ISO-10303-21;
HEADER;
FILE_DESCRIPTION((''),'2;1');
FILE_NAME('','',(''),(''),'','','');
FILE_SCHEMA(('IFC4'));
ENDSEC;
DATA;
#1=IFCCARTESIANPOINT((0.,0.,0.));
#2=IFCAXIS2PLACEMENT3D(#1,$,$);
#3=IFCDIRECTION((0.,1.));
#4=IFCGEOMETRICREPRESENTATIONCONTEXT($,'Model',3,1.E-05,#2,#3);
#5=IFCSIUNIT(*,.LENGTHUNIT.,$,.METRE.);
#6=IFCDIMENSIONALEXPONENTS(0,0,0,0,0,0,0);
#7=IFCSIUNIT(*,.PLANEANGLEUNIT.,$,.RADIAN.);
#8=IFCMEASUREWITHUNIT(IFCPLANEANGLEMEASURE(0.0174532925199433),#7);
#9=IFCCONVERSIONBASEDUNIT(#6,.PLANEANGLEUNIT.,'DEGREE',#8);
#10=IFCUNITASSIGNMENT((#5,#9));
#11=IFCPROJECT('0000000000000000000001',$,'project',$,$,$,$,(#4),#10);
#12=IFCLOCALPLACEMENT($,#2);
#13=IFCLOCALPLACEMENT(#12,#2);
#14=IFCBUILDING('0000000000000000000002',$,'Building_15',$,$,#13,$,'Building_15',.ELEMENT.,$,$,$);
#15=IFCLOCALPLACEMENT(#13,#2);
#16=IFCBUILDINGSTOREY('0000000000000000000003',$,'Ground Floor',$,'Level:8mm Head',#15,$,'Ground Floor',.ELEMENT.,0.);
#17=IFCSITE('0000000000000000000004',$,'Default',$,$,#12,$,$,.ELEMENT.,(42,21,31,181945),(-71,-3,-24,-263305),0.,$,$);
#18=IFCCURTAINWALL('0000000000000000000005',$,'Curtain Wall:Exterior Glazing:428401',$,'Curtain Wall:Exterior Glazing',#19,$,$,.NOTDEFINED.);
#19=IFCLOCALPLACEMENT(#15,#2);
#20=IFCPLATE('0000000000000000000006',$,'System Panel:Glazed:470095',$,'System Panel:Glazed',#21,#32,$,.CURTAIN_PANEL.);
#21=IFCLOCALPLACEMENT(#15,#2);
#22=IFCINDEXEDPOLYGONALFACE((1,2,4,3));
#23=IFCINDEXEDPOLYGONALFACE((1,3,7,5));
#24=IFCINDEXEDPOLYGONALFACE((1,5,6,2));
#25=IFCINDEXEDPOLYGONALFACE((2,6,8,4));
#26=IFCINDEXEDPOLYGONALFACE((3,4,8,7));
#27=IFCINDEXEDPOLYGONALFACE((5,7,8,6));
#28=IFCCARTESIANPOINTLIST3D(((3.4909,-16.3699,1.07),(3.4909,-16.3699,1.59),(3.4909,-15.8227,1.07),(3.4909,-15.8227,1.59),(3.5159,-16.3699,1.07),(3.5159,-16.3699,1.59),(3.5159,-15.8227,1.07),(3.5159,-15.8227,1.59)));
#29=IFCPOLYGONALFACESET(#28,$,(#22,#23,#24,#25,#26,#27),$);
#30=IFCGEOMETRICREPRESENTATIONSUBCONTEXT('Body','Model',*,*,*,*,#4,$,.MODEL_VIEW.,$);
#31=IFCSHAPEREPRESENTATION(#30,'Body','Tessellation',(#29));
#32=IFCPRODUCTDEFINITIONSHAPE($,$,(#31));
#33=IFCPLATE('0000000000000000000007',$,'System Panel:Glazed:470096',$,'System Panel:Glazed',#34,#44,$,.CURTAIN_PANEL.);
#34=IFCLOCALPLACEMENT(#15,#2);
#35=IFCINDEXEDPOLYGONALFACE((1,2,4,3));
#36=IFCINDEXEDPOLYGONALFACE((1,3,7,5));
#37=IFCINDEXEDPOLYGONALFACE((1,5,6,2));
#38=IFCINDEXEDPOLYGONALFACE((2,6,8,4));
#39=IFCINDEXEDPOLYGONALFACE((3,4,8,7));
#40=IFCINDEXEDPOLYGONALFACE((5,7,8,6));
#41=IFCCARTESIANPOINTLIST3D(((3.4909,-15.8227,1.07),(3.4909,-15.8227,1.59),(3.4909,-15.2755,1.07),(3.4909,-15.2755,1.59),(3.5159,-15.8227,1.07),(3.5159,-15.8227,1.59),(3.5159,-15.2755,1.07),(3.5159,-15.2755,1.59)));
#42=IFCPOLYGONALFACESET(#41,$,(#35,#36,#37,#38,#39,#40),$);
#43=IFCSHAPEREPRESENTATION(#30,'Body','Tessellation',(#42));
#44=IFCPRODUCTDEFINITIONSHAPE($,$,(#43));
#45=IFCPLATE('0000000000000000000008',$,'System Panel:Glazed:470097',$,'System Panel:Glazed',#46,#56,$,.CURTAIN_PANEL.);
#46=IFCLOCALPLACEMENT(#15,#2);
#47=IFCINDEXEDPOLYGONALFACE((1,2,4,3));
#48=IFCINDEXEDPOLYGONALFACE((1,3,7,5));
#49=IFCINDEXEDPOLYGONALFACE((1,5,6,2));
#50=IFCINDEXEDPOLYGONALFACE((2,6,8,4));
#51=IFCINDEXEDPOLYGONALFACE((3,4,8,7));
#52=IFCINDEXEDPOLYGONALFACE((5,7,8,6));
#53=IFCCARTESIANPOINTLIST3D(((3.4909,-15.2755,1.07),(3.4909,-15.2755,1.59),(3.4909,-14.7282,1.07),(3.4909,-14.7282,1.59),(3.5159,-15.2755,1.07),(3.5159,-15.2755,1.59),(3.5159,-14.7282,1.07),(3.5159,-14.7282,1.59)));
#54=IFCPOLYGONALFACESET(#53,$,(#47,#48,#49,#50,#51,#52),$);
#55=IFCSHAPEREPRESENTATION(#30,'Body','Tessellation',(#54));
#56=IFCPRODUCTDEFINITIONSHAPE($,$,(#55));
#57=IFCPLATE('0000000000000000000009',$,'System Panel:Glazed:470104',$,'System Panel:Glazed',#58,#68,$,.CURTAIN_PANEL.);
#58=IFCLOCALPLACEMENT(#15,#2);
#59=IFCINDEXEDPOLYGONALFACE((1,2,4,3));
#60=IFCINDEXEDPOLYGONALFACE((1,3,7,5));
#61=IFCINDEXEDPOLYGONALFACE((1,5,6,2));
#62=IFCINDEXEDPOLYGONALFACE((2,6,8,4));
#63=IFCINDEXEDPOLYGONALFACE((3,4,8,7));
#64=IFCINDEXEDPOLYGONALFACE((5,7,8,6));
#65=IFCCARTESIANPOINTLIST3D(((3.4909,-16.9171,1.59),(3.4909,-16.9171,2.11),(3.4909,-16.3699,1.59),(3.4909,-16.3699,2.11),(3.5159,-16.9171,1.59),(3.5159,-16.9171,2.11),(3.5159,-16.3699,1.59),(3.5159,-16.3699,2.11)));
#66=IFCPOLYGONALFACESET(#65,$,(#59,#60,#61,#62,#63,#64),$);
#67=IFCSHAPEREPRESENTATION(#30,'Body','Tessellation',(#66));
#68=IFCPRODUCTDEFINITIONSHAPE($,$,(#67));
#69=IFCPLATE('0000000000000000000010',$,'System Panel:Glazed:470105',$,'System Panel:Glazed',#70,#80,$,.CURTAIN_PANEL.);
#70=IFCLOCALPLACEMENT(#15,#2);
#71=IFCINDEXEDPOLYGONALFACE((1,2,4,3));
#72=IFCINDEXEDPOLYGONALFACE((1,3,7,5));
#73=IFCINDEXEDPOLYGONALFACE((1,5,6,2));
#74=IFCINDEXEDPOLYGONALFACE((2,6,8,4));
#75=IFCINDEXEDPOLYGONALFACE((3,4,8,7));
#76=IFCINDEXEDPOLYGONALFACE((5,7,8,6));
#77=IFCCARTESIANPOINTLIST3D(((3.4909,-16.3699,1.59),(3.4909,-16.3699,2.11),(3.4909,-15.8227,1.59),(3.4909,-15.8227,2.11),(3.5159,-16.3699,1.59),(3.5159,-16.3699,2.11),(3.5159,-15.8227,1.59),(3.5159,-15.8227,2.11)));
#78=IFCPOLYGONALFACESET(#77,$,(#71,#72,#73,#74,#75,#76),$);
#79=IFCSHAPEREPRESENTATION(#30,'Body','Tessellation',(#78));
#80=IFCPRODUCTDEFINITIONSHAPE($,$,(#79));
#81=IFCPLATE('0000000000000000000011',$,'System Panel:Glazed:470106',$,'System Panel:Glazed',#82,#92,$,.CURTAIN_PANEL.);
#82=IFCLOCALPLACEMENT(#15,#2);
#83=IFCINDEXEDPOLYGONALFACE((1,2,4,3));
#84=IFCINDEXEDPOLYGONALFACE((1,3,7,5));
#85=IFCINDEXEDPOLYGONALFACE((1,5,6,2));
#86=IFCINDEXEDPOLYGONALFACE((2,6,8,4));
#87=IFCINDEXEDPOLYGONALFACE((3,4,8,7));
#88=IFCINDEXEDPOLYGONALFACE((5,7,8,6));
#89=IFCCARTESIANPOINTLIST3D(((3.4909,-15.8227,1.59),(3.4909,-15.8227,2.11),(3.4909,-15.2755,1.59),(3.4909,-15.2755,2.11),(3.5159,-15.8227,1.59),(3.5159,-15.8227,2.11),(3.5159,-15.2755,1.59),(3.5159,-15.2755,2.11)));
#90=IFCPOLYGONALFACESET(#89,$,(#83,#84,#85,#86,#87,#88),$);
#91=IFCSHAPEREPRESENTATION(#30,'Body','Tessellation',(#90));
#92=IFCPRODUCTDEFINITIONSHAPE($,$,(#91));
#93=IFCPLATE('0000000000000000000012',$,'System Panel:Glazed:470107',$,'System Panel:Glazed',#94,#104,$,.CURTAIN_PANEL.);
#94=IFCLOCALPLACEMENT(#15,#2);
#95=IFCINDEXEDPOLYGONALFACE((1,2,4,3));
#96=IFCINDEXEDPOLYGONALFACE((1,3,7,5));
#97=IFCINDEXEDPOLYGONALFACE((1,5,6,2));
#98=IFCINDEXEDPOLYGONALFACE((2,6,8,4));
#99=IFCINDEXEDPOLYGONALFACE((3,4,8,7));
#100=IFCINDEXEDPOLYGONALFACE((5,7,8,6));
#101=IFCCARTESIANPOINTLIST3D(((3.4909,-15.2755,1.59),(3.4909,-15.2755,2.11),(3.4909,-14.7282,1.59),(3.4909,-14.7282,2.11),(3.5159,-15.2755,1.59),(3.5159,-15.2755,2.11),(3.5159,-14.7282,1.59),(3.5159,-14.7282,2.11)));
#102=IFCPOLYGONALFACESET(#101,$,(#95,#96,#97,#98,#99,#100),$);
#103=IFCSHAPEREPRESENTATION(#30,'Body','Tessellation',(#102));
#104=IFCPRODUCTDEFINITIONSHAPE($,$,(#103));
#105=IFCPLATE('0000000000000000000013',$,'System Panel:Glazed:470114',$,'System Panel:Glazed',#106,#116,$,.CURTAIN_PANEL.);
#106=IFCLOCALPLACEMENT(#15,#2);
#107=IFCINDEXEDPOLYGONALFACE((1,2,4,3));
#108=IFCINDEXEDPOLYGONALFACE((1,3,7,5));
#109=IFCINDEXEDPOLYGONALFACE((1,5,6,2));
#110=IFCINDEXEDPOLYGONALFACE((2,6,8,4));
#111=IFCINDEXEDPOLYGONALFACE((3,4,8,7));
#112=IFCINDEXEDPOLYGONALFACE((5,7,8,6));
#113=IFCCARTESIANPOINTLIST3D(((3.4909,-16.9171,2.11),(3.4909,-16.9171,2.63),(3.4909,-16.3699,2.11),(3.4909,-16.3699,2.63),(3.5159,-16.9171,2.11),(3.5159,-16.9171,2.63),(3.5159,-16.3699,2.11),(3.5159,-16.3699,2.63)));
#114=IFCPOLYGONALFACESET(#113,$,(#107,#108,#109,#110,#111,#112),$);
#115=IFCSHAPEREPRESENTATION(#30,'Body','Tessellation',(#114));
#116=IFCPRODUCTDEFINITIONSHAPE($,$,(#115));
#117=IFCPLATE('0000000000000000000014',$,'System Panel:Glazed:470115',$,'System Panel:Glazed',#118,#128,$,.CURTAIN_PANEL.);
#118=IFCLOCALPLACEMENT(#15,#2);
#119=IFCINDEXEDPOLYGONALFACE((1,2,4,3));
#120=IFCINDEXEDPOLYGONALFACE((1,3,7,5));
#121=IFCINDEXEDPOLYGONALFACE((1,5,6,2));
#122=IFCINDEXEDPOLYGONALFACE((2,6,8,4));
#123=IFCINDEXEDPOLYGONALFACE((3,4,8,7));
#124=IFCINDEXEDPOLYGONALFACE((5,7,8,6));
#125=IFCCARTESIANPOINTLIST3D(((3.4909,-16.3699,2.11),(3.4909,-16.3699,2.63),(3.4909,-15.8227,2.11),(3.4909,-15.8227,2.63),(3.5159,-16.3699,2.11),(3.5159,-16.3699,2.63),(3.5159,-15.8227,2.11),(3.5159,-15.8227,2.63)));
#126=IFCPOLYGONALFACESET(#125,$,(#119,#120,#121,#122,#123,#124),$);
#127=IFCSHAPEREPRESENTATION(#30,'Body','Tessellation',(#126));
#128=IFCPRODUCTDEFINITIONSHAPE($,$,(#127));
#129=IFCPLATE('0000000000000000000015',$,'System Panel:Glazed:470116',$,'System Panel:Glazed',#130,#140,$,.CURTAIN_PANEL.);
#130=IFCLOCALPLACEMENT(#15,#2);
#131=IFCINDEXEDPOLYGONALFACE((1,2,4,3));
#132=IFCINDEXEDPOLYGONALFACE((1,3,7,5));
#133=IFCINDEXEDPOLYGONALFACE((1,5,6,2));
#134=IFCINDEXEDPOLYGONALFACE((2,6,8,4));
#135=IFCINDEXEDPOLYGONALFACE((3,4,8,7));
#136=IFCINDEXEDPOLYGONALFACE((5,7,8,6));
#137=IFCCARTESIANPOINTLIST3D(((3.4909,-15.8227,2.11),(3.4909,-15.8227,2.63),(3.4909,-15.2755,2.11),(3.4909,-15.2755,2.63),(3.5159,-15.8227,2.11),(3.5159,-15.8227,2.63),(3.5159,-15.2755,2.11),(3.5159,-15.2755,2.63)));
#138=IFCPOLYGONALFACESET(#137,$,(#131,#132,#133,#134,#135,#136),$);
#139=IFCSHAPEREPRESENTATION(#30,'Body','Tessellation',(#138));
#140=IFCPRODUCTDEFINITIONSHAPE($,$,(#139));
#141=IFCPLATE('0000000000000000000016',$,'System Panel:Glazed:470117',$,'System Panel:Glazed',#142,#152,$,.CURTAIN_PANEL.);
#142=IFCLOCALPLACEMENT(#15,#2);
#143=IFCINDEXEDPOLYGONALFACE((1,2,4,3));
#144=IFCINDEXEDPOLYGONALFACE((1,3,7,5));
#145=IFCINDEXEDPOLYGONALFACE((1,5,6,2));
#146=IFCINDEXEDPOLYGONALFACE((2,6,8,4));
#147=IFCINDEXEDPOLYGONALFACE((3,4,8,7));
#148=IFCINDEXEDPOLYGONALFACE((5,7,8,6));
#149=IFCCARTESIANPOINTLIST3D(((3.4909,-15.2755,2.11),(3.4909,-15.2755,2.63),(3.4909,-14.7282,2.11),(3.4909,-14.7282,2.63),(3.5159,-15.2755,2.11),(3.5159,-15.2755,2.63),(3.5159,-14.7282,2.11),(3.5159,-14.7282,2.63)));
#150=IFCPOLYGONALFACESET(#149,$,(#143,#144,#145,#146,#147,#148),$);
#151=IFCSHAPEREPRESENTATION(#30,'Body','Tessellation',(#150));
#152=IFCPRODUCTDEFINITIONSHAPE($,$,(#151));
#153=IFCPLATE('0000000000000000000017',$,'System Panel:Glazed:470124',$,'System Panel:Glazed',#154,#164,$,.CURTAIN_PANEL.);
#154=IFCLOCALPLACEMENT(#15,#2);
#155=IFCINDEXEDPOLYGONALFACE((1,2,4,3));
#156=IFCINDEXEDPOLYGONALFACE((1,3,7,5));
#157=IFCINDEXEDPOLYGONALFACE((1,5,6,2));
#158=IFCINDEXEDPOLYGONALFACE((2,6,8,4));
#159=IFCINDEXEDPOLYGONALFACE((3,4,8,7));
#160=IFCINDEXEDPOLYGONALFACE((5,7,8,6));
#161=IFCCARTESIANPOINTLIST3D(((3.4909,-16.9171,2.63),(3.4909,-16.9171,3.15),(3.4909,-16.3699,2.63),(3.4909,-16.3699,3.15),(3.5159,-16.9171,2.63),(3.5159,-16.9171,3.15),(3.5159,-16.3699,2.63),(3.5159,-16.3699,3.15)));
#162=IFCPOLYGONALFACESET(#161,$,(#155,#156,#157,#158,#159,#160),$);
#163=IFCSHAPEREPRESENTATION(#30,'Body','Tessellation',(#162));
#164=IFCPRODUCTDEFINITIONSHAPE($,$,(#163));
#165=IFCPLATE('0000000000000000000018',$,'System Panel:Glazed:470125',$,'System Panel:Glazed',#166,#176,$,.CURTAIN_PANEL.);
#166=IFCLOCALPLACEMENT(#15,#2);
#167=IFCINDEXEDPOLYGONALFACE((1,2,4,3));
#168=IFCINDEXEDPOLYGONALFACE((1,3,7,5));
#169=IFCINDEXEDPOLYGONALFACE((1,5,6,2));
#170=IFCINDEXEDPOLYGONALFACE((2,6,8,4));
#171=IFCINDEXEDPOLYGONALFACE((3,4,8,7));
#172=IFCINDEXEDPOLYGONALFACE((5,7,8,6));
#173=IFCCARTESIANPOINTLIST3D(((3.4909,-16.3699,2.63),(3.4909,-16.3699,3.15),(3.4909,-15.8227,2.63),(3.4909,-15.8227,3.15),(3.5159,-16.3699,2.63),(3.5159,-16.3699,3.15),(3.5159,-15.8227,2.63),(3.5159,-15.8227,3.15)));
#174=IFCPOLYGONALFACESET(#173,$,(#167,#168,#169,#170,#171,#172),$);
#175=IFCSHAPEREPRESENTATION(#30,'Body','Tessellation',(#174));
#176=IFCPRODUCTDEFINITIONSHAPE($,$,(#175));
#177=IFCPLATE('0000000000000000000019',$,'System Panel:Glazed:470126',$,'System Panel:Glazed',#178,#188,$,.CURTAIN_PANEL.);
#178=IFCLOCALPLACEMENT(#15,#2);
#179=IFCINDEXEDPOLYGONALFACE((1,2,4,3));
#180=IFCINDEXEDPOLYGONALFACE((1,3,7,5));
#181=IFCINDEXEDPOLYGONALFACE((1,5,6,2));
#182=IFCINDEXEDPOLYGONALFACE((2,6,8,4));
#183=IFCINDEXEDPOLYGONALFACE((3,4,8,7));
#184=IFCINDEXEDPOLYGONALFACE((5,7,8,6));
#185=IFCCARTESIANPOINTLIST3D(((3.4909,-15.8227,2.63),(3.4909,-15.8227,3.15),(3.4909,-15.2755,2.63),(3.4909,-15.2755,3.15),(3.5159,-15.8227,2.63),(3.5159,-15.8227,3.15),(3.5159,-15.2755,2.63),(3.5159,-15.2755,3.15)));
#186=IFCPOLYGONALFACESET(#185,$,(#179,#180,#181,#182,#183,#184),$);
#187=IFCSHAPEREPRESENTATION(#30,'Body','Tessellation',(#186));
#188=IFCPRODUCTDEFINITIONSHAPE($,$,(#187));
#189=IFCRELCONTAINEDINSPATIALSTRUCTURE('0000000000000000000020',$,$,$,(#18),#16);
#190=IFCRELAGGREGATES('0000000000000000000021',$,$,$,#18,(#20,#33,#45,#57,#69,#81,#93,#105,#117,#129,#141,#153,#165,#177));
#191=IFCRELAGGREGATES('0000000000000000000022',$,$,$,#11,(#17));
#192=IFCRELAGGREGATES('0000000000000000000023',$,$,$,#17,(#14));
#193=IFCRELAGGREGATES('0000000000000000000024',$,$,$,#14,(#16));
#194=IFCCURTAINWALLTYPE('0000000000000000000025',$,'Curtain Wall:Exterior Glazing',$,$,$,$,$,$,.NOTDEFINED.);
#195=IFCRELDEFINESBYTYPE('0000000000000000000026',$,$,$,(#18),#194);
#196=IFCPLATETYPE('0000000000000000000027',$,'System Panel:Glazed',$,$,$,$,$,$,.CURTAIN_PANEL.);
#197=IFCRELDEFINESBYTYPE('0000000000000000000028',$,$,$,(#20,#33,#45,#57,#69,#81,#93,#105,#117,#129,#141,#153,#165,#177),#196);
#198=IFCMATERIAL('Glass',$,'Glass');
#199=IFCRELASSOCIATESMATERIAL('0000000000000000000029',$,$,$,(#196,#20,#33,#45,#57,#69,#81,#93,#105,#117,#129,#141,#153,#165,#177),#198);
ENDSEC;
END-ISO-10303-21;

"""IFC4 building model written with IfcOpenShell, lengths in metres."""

from ifc_helpers import new_model, entity, si_unit, converted_unit, direction, frame, origin, place, context, subcontext, project, spatial, indexed_curve, outline, extrude, source, transform, mapped, material, type_object, type_shapes, element, aggregate, save


model = new_model("IFC4")

# Units and contexts
model_context = context("Model", 3, precision=1e-05, world=origin(), true_north=direction((0.0, 1.0)))
body_context = subcontext(model_context, "Body", "Model", "MODEL_VIEW")
ifc_project = project(units=[si_unit("LENGTHUNIT", "METRE"), converted_unit("PLANEANGLEUNIT", "DEGREE", entity("IfcPlaneAngleMeasure", 0.0174532925199433), si_unit("PLANEANGLEUNIT", "RADIAN"), dimensions=[0, 0, 0, 0, 0, 0, 0])], contexts=[model_context])

# Site, building, storey
site_placement = place(None, origin())
site = spatial("IfcSite", under=ifc_project, at=site_placement, Name="Default", CompositionType="ELEMENT", RefLatitude=(42, 21, 31, 181945), RefLongitude=(-71, -3, -24, -263305), RefElevation=0.0)
building_placement = place(site_placement, origin())
building = spatial("IfcBuilding", under=site, at=building_placement, Name="Building_15", LongName="Building_15", CompositionType="ELEMENT")
storey_placement = place(building_placement, origin())
storey = spatial("IfcBuildingStorey", under=building, at=storey_placement, Name="Ground Floor", ObjectType="Level:8mm Head", LongName="Ground Floor", CompositionType="ELEMENT", Elevation=0.0)

# Curtain wall, plates
curtain_wall_type = type_object("IfcCurtainWallType", Name="Curtain Wall:Exterior Glazing", PredefinedType="NOTDEFINED")
curtain_wall_placement = place(storey_placement, origin())
curtain_wall = element("IfcCurtainWall", 1, at=curtain_wall_placement, inside=storey, type_object=curtain_wall_type, Name="Curtain Wall:Exterior Glazing:428401", ObjectType="Curtain Wall:Exterior Glazing", PredefinedType="NOTDEFINED")
ifc_material_1 = material(Name="Glass", Category="Glass")
plate_type_1 = type_object("IfcPlateType", Name="System Panel:Glazed", PredefinedType="CURTAIN_PANEL", material=ifc_material_1)
shared_shape_1 = source(origin(), body_context, "Body", "SweptSolid", [
    extrude(outline(indexed_curve([(-0.0125, -0.2736), (0.0125, -0.2736), (0.0125, 0.2736), (-0.0125, 0.2736), (-0.0125, -0.2736)], self_intersect=False)), frame((0.0, 0.037, 0.0), z_axis=(0.0, 0.0, 1.0), x_axis=(0.0, 1.0, 0.0)), (0.0, 0.0, 1.0), 0.52),
])
type_shapes(plate_type_1, [shared_shape_1])
plate_1_placement = place(curtain_wall_placement, frame((3.5404, -16.0963, 1.07), z_axis=(0.0, 0.0, 1.0), x_axis=(0.0, 1.0, 0.0)))
plate_1 = element("IfcPlate", 2, at=plate_1_placement, type_object=plate_type_1, material=ifc_material_1, Name="System Panel:Glazed:470095", ObjectType="System Panel:Glazed", PredefinedType="CURTAIN_PANEL", context=body_context, shape_type="MappedRepresentation", body=[
    mapped(shared_shape_1, transform((0.0, 0.0, 0.0), scale=1.0)),
])
plate_2_placement = place(curtain_wall_placement, frame((3.5404, -15.5491, 1.07), z_axis=(0.0, 0.0, 1.0), x_axis=(0.0, 1.0, 0.0)))
plate_2 = element("IfcPlate", 3, at=plate_2_placement, type_object=plate_type_1, material=ifc_material_1, Name="System Panel:Glazed:470096", ObjectType="System Panel:Glazed", PredefinedType="CURTAIN_PANEL", context=body_context, shape_type="MappedRepresentation", body=[
    mapped(shared_shape_1, transform((0.0, 0.0, 0.0), scale=1.0)),
])
plate_3_placement = place(curtain_wall_placement, frame((3.5404, -15.0018, 1.07), z_axis=(0.0, 0.0, 1.0), x_axis=(0.0, 1.0, 0.0)))
plate_3 = element("IfcPlate", 4, at=plate_3_placement, type_object=plate_type_1, material=ifc_material_1, Name="System Panel:Glazed:470097", ObjectType="System Panel:Glazed", PredefinedType="CURTAIN_PANEL", context=body_context, shape_type="MappedRepresentation", body=[
    mapped(shared_shape_1, transform((0.0, 0.0, 0.0), scale=1.0)),
])
plate_4_placement = place(curtain_wall_placement, frame((3.5404, -16.6435, 1.59), z_axis=(0.0, 0.0, 1.0), x_axis=(0.0, 1.0, 0.0)))
plate_4 = element("IfcPlate", 5, at=plate_4_placement, type_object=plate_type_1, material=ifc_material_1, Name="System Panel:Glazed:470104", ObjectType="System Panel:Glazed", PredefinedType="CURTAIN_PANEL", context=body_context, shape_type="MappedRepresentation", body=[
    mapped(shared_shape_1, transform((0.0, 0.0, 0.0), scale=1.0)),
])
plate_5_placement = place(curtain_wall_placement, frame((3.5404, -16.0963, 1.59), z_axis=(0.0, 0.0, 1.0), x_axis=(0.0, 1.0, 0.0)))
plate_5 = element("IfcPlate", 6, at=plate_5_placement, type_object=plate_type_1, material=ifc_material_1, Name="System Panel:Glazed:470105", ObjectType="System Panel:Glazed", PredefinedType="CURTAIN_PANEL", context=body_context, shape_type="MappedRepresentation", body=[
    mapped(shared_shape_1, transform((0.0, 0.0, 0.0), scale=1.0)),
])
plate_6_placement = place(curtain_wall_placement, frame((3.5404, -15.5491, 1.59), z_axis=(0.0, 0.0, 1.0), x_axis=(0.0, 1.0, 0.0)))
plate_6 = element("IfcPlate", 7, at=plate_6_placement, type_object=plate_type_1, material=ifc_material_1, Name="System Panel:Glazed:470106", ObjectType="System Panel:Glazed", PredefinedType="CURTAIN_PANEL", context=body_context, shape_type="MappedRepresentation", body=[
    mapped(shared_shape_1, transform((0.0, 0.0, 0.0), scale=1.0)),
])
plate_7_placement = place(curtain_wall_placement, frame((3.5404, -15.0018, 1.59), z_axis=(0.0, 0.0, 1.0), x_axis=(0.0, 1.0, 0.0)))
plate_7 = element("IfcPlate", 8, at=plate_7_placement, type_object=plate_type_1, material=ifc_material_1, Name="System Panel:Glazed:470107", ObjectType="System Panel:Glazed", PredefinedType="CURTAIN_PANEL", context=body_context, shape_type="MappedRepresentation", body=[
    mapped(shared_shape_1, transform((0.0, 0.0, 0.0), scale=1.0)),
])
plate_8_placement = place(curtain_wall_placement, frame((3.5404, -16.6435, 2.11), z_axis=(0.0, 0.0, 1.0), x_axis=(0.0, 1.0, 0.0)))
plate_8 = element("IfcPlate", 9, at=plate_8_placement, type_object=plate_type_1, material=ifc_material_1, Name="System Panel:Glazed:470114", ObjectType="System Panel:Glazed", PredefinedType="CURTAIN_PANEL", context=body_context, shape_type="MappedRepresentation", body=[
    mapped(shared_shape_1, transform((0.0, 0.0, 0.0), scale=1.0)),
])
plate_9_placement = place(curtain_wall_placement, frame((3.5404, -16.0963, 2.11), z_axis=(0.0, 0.0, 1.0), x_axis=(0.0, 1.0, 0.0)))
plate_9 = element("IfcPlate", 10, at=plate_9_placement, type_object=plate_type_1, material=ifc_material_1, Name="System Panel:Glazed:470115", ObjectType="System Panel:Glazed", PredefinedType="CURTAIN_PANEL", context=body_context, shape_type="MappedRepresentation", body=[
    mapped(shared_shape_1, transform((0.0, 0.0, 0.0), scale=1.0)),
])
plate_10_placement = place(curtain_wall_placement, frame((3.5404, -15.5491, 2.11), z_axis=(0.0, 0.0, 1.0), x_axis=(0.0, 1.0, 0.0)))
plate_10 = element("IfcPlate", 11, at=plate_10_placement, type_object=plate_type_1, material=ifc_material_1, Name="System Panel:Glazed:470116", ObjectType="System Panel:Glazed", PredefinedType="CURTAIN_PANEL", context=body_context, shape_type="MappedRepresentation", body=[
    mapped(shared_shape_1, transform((0.0, 0.0, 0.0), scale=1.0)),
])
plate_11_placement = place(curtain_wall_placement, frame((3.5404, -15.0018, 2.11), z_axis=(0.0, 0.0, 1.0), x_axis=(0.0, 1.0, 0.0)))
plate_11 = element("IfcPlate", 12, at=plate_11_placement, type_object=plate_type_1, material=ifc_material_1, Name="System Panel:Glazed:470117", ObjectType="System Panel:Glazed", PredefinedType="CURTAIN_PANEL", context=body_context, shape_type="MappedRepresentation", body=[
    mapped(shared_shape_1, transform((0.0, 0.0, 0.0), scale=1.0)),
])
plate_12_placement = place(curtain_wall_placement, frame((3.5404, -16.6435, 2.63), z_axis=(0.0, 0.0, 1.0), x_axis=(0.0, 1.0, 0.0)))
plate_12 = element("IfcPlate", 13, at=plate_12_placement, type_object=plate_type_1, material=ifc_material_1, Name="System Panel:Glazed:470124", ObjectType="System Panel:Glazed", PredefinedType="CURTAIN_PANEL", context=body_context, shape_type="MappedRepresentation", body=[
    mapped(shared_shape_1, transform((0.0, 0.0, 0.0), scale=1.0)),
])
plate_13_placement = place(curtain_wall_placement, frame((3.5404, -16.0963, 2.63), z_axis=(0.0, 0.0, 1.0), x_axis=(0.0, 1.0, 0.0)))
plate_13 = element("IfcPlate", 14, at=plate_13_placement, type_object=plate_type_1, material=ifc_material_1, Name="System Panel:Glazed:470125", ObjectType="System Panel:Glazed", PredefinedType="CURTAIN_PANEL", context=body_context, shape_type="MappedRepresentation", body=[
    mapped(shared_shape_1, transform((0.0, 0.0, 0.0), scale=1.0)),
])
plate_14_placement = place(curtain_wall_placement, frame((3.5404, -15.5491, 2.63), z_axis=(0.0, 0.0, 1.0), x_axis=(0.0, 1.0, 0.0)))
plate_14 = element("IfcPlate", 15, at=plate_14_placement, type_object=plate_type_1, material=ifc_material_1, Name="System Panel:Glazed:470126", ObjectType="System Panel:Glazed", PredefinedType="CURTAIN_PANEL", context=body_context, shape_type="MappedRepresentation", body=[
    mapped(shared_shape_1, transform((0.0, 0.0, 0.0), scale=1.0)),
])
aggregate(curtain_wall, [plate_1, plate_2, plate_3, plate_4, plate_5, plate_6, plate_7, plate_8, plate_9, plate_10, plate_11, plate_12, plate_13, plate_14])

save(model, "model.ifc")
